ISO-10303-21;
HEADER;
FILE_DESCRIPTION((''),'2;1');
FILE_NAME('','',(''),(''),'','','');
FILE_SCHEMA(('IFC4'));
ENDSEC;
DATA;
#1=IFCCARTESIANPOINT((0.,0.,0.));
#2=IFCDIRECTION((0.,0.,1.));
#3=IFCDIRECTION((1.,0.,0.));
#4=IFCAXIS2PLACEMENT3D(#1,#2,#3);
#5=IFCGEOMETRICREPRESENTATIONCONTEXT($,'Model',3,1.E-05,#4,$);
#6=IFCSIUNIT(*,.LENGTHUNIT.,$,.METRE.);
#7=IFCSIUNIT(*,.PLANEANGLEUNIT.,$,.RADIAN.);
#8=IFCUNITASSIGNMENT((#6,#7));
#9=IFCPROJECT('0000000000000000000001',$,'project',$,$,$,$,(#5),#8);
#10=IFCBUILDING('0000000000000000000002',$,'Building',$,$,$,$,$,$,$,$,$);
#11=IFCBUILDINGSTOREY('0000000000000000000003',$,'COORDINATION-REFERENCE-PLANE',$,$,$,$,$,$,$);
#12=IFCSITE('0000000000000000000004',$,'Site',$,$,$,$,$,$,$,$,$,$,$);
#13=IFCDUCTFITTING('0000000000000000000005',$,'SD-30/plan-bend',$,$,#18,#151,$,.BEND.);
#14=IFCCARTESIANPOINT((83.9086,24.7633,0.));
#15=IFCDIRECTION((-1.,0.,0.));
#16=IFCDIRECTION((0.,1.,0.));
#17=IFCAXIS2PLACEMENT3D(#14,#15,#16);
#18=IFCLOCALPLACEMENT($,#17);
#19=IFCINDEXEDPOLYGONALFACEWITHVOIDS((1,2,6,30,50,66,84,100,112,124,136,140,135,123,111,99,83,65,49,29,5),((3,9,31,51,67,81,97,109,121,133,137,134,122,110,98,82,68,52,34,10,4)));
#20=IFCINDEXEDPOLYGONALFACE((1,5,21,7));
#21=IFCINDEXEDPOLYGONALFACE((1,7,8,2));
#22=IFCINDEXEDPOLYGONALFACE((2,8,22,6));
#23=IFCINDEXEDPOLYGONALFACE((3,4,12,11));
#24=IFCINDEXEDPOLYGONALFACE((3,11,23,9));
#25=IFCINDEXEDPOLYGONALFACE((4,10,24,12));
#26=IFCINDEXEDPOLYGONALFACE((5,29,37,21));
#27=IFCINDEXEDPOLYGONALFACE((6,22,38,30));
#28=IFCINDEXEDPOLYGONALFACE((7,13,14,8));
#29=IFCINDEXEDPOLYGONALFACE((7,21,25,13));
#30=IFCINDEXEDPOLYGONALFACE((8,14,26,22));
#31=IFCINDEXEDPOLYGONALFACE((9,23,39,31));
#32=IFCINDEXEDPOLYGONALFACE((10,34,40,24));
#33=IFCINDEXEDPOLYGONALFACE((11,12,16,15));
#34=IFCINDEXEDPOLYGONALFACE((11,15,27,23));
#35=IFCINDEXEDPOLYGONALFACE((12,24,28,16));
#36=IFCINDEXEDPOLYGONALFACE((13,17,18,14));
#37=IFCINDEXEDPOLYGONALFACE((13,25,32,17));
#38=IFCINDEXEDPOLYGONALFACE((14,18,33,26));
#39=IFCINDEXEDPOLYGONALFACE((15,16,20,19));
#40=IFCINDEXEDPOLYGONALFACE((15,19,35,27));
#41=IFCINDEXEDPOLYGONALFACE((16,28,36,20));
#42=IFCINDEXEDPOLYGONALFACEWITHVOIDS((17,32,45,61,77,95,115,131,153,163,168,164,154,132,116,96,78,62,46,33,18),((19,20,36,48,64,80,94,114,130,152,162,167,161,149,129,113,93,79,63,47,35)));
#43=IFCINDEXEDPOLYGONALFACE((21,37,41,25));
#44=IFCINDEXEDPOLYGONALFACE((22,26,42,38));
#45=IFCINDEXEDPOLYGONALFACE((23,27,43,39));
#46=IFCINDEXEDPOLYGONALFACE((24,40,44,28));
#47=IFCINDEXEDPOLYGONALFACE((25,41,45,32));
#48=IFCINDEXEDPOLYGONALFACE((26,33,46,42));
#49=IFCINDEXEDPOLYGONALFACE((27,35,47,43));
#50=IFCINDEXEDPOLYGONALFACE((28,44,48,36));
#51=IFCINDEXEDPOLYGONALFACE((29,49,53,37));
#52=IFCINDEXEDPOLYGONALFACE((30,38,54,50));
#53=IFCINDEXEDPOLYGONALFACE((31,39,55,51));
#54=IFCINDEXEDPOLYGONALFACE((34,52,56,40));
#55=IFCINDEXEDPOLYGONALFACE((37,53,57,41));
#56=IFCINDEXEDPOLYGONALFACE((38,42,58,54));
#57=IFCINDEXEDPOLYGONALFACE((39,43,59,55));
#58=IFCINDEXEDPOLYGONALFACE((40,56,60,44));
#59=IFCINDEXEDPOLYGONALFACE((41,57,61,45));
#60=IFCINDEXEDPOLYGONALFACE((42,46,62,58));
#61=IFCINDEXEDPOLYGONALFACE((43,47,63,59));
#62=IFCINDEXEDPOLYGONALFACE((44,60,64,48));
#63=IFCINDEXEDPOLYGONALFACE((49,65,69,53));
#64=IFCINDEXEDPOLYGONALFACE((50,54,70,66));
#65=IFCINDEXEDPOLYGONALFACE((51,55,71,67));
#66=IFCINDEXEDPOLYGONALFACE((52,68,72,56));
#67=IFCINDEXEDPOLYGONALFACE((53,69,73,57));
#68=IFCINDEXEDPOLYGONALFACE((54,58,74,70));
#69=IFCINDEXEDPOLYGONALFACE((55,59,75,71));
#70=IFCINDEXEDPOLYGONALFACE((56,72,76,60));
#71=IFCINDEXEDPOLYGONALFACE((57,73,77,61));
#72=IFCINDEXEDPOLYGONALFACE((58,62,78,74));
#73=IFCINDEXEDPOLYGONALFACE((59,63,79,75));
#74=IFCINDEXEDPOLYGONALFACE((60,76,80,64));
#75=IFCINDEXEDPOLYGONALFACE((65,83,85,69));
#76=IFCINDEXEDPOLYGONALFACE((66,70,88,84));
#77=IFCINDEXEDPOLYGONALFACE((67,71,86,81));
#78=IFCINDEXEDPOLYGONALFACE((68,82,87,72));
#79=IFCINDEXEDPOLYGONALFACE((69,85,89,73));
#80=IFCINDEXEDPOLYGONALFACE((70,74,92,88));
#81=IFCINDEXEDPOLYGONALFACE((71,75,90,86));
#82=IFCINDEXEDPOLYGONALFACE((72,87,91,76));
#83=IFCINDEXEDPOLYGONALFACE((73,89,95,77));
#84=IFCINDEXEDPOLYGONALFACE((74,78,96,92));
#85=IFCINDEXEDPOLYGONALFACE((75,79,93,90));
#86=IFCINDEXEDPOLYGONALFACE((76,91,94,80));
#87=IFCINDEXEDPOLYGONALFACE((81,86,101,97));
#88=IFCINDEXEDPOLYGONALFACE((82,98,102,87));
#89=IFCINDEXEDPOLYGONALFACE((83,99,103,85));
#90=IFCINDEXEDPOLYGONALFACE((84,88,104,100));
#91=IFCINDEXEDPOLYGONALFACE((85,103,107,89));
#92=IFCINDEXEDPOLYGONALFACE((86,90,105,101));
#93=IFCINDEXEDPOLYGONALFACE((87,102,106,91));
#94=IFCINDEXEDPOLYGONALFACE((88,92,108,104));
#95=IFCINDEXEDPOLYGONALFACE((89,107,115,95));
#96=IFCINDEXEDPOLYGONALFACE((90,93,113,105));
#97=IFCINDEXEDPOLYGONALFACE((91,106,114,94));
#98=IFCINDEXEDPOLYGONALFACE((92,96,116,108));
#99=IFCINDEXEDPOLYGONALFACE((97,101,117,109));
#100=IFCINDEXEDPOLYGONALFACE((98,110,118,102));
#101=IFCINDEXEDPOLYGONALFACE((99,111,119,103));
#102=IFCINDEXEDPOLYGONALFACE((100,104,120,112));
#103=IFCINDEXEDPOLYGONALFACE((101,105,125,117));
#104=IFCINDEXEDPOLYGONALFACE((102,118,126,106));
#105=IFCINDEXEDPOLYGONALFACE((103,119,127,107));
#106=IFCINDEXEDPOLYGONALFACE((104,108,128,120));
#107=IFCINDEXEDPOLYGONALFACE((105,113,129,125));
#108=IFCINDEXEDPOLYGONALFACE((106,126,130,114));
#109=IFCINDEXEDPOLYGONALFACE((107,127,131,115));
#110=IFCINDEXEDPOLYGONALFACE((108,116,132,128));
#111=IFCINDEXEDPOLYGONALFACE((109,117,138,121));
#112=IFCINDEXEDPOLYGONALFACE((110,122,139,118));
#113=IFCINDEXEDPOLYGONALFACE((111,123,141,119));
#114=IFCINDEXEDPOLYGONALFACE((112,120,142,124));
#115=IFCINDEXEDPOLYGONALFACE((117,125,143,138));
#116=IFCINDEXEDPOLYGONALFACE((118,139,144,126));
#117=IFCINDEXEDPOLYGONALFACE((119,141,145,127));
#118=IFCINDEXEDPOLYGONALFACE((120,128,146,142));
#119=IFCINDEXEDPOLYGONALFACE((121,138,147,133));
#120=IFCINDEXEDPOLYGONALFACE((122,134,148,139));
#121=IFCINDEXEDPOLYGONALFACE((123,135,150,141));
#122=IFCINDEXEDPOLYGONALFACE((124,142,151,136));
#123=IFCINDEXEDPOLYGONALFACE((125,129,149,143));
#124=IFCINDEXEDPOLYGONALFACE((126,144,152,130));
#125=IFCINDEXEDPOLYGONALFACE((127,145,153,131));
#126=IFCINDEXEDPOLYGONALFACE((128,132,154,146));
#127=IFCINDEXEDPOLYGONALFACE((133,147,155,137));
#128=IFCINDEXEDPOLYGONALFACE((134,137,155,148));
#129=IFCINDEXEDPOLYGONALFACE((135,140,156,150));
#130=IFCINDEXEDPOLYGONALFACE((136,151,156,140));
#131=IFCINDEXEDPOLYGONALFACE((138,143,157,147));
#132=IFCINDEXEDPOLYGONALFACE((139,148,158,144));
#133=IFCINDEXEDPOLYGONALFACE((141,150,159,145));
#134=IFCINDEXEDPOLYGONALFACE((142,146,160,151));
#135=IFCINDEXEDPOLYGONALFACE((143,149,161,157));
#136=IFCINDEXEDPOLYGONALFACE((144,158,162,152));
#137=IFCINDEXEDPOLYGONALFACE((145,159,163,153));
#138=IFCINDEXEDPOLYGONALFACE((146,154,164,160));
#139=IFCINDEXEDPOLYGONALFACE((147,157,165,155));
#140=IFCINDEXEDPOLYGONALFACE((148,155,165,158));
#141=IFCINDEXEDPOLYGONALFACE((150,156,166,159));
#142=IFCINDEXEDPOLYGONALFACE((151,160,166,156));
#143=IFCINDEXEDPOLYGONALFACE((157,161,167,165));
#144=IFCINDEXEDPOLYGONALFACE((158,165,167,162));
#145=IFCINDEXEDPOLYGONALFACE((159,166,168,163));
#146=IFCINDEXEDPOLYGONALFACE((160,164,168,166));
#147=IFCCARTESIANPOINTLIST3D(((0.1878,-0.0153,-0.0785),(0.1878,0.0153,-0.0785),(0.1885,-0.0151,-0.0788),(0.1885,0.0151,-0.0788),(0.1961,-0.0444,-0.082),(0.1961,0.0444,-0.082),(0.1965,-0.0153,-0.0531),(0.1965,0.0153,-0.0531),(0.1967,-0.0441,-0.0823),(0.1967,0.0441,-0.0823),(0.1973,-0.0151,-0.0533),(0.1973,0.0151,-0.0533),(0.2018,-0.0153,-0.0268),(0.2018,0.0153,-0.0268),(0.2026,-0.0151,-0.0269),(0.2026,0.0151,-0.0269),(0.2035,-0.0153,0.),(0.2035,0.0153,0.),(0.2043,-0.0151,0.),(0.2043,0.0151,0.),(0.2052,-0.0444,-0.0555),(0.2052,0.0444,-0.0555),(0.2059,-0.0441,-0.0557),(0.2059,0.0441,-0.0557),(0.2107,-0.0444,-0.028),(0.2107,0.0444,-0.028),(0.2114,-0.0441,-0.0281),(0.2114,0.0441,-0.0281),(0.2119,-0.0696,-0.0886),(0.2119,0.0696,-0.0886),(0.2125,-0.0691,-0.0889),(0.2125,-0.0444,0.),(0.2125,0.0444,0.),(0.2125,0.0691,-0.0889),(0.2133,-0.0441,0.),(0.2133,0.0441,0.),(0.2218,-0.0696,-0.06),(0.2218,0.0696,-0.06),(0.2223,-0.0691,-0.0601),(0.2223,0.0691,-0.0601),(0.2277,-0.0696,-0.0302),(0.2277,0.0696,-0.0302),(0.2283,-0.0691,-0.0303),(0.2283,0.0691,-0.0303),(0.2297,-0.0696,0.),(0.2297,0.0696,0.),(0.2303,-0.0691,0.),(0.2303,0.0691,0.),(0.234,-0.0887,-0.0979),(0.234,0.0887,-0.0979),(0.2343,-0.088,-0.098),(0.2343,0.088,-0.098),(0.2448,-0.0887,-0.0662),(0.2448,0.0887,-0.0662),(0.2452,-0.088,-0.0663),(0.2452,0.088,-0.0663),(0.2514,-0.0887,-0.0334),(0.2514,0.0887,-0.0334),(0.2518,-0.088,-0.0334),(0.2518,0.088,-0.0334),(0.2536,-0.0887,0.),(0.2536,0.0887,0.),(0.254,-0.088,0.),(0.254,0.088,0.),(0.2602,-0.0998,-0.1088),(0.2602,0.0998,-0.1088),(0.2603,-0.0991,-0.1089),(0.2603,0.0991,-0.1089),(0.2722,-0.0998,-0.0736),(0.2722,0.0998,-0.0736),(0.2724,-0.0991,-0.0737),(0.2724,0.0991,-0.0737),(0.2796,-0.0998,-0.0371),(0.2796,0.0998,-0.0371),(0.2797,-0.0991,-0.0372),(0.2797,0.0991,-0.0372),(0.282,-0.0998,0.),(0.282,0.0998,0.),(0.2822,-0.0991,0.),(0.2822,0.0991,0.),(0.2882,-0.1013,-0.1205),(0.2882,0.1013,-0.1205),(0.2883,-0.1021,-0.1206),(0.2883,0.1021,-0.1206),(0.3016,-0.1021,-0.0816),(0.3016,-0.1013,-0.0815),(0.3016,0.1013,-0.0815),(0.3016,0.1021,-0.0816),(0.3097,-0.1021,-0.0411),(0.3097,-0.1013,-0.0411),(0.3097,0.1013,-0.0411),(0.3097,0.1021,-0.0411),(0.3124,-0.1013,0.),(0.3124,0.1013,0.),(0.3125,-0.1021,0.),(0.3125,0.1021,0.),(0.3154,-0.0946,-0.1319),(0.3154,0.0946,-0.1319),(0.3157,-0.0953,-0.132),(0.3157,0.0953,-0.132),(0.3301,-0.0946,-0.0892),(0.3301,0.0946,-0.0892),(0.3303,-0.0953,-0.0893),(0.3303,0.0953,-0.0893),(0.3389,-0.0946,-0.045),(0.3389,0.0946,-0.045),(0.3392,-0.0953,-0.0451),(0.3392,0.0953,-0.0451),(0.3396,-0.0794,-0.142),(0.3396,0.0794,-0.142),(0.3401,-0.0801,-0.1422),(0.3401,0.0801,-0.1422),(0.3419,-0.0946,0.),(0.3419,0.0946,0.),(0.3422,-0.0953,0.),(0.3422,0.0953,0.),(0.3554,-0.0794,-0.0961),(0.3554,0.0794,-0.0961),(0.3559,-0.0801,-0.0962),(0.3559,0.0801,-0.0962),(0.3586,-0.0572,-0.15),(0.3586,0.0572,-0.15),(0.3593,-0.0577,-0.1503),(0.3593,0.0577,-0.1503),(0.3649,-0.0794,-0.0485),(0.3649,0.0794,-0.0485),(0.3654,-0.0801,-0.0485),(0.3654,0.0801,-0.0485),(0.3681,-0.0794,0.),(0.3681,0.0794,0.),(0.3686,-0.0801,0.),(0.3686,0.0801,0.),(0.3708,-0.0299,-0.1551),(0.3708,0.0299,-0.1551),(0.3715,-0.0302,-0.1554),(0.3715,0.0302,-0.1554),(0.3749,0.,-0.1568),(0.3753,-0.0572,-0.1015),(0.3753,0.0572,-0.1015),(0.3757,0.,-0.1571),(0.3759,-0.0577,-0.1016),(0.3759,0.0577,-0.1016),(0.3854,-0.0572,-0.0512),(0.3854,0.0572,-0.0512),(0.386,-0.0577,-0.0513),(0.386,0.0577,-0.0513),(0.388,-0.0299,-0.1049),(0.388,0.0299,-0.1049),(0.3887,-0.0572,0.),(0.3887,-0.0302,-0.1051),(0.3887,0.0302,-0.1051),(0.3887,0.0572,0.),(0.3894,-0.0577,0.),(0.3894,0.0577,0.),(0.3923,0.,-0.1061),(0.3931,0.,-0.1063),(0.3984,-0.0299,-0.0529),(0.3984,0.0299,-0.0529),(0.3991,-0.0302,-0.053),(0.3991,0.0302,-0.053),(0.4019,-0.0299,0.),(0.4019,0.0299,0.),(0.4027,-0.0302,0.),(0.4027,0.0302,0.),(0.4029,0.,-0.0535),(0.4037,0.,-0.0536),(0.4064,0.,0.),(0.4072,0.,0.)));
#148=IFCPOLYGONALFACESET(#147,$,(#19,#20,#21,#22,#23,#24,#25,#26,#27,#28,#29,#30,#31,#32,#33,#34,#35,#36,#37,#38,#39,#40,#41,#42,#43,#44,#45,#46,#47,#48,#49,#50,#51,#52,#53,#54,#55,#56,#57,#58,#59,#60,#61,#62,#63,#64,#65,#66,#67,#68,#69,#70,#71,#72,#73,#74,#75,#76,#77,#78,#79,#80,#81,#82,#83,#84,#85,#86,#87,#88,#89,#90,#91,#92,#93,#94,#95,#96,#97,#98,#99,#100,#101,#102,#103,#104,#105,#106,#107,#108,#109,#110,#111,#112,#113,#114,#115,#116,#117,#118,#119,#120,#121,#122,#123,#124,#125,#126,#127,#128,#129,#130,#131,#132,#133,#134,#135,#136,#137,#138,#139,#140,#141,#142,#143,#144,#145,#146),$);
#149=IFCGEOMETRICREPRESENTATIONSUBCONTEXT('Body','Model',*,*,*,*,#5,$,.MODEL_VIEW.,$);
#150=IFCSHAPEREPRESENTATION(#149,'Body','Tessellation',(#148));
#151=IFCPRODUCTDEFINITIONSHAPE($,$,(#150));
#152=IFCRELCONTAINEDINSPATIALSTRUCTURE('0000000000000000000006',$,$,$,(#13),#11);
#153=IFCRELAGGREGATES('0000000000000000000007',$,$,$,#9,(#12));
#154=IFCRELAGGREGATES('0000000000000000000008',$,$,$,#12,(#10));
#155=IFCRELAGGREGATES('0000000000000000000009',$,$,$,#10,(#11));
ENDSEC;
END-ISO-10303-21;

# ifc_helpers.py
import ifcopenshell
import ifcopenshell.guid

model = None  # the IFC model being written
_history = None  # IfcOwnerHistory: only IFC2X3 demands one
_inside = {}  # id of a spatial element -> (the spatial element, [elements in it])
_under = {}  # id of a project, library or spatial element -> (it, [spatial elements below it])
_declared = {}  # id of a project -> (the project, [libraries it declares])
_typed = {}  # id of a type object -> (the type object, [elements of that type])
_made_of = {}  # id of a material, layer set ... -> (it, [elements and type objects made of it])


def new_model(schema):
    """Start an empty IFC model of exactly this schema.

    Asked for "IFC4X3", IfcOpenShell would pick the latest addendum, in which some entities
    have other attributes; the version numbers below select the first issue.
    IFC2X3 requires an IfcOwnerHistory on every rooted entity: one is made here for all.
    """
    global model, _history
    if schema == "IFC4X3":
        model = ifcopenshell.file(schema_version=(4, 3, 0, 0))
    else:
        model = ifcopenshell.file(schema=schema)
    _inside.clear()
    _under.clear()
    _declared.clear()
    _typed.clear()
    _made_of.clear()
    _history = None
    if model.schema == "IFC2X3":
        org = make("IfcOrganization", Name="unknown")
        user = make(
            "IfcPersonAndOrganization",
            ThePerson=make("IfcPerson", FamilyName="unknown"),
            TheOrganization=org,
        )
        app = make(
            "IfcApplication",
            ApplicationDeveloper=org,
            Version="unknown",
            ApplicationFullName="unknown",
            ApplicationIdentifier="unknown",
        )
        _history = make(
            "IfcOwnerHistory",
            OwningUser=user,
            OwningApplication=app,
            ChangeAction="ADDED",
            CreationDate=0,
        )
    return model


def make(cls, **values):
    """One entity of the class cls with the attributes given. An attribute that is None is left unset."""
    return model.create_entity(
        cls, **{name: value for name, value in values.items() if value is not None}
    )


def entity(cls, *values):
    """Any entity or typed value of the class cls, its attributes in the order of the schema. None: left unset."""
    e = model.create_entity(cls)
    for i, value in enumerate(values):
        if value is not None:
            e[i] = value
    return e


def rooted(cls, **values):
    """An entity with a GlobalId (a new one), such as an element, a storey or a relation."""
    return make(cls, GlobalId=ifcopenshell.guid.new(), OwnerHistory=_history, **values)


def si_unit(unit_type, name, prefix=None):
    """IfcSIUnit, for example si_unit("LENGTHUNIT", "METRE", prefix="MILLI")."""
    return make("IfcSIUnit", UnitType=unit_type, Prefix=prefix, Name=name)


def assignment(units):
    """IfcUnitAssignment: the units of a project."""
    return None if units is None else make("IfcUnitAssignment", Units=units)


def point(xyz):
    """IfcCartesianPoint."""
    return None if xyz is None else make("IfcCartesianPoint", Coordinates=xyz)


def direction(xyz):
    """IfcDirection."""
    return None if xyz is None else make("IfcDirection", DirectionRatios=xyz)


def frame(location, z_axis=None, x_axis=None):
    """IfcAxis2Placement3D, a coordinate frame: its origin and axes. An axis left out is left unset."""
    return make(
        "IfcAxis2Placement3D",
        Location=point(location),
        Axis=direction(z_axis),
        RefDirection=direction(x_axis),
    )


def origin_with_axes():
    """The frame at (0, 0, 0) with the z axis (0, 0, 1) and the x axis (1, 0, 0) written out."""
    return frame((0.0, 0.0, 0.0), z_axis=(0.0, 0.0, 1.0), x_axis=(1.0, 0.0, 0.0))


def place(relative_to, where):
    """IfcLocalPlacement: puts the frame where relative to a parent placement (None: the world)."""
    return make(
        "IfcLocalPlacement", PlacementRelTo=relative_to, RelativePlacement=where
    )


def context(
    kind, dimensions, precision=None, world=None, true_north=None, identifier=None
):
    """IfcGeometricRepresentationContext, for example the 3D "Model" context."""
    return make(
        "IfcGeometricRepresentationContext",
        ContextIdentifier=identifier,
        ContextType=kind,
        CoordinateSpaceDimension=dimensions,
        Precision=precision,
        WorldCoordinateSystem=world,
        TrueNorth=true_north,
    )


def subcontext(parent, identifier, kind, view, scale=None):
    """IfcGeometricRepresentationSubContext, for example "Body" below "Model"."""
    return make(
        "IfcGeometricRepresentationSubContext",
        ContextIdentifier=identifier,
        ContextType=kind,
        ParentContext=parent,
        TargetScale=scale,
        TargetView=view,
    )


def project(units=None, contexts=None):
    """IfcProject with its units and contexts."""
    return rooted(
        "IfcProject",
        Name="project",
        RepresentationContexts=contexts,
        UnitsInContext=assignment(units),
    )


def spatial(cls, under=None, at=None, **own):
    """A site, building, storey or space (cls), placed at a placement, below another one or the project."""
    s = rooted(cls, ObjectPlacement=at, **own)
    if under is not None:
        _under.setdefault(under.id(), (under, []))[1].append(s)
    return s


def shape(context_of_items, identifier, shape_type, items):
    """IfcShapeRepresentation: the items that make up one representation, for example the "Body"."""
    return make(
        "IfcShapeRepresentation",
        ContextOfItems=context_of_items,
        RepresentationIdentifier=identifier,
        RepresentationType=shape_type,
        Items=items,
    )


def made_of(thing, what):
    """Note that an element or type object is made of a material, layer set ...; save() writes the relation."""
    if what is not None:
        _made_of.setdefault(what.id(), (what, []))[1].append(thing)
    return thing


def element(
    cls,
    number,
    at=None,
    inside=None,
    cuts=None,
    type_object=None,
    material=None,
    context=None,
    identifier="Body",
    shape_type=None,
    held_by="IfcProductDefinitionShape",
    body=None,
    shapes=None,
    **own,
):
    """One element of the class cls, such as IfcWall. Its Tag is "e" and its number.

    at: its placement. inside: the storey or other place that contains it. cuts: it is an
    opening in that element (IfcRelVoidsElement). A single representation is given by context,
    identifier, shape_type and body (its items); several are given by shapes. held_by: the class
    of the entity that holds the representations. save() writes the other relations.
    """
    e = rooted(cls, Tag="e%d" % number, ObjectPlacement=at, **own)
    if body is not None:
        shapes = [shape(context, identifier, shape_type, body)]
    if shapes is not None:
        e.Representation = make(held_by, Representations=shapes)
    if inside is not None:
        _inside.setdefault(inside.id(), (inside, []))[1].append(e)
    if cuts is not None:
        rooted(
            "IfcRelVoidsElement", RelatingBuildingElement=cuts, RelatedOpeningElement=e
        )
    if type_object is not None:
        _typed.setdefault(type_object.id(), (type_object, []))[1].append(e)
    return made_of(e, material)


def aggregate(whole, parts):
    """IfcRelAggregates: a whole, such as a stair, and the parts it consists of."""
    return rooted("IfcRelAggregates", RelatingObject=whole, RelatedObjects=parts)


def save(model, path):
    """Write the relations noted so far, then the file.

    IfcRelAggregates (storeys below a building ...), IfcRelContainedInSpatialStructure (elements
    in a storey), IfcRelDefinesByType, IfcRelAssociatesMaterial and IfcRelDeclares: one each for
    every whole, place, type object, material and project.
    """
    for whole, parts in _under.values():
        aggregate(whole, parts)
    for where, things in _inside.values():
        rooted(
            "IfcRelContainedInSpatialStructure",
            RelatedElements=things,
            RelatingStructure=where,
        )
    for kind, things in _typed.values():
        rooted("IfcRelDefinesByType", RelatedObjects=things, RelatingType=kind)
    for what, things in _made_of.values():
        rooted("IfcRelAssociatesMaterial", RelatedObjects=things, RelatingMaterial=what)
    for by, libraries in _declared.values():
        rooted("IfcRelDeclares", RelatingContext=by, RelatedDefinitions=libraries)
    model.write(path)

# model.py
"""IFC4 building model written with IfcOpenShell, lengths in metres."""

from ifc_helpers import new_model, entity, si_unit, frame, origin_with_axes, place, context, subcontext, project, spatial, element, save


model = new_model("IFC4")

# Units and contexts
model_context = context("Model", 3, precision=1e-05, world=origin_with_axes())
body_context_1 = subcontext(model_context, "Body", "Model", "MODEL_VIEW")
ifc_project = project(units=[si_unit("LENGTHUNIT", "METRE"), si_unit("PLANEANGLEUNIT", "RADIAN")], contexts=[model_context])

# Site, building, storey
site = spatial("IfcSite", under=ifc_project, Name="Site")
building = spatial("IfcBuilding", under=site, Name="Building")
storey = spatial("IfcBuildingStorey", under=building, Name="COORDINATION-REFERENCE-PLANE")

# Duct fitting
duct_fitting_1_placement = place(None, frame((83.9086, 24.7633, 0.0), z_axis=(-1.0, 0.0, 0.0), x_axis=(0.0, 1.0, 0.0)))
element("IfcDuctFitting", 1, at=duct_fitting_1_placement, inside=storey, Name="SD-30/plan-bend", PredefinedType="BEND", context=body_context_1, shape_type="SweptSolid", body=[
    entity("IfcRevolvedAreaSolid", entity("IfcCircleHollowProfileDef", "AREA", None, entity("IfcAxis2Placement2D", entity("IfcCartesianPoint", [0.3048, 0.0])), 0.1024, 0.0008), entity("IfcAxis2Placement3D", entity("IfcCartesianPoint", [0.0, 0.0, 0.0]), entity("IfcDirection", [0.0, 0.0, 1.0]), entity("IfcDirection", [1.0, 0.0, 0.0])), entity("IfcAxis1Placement", entity("IfcCartesianPoint", [0.0, 0.0, 0.0]), entity("IfcDirection", [0.0, 1.0, 0.0])), 0.396124),
])

save(model, "model.ifc")
